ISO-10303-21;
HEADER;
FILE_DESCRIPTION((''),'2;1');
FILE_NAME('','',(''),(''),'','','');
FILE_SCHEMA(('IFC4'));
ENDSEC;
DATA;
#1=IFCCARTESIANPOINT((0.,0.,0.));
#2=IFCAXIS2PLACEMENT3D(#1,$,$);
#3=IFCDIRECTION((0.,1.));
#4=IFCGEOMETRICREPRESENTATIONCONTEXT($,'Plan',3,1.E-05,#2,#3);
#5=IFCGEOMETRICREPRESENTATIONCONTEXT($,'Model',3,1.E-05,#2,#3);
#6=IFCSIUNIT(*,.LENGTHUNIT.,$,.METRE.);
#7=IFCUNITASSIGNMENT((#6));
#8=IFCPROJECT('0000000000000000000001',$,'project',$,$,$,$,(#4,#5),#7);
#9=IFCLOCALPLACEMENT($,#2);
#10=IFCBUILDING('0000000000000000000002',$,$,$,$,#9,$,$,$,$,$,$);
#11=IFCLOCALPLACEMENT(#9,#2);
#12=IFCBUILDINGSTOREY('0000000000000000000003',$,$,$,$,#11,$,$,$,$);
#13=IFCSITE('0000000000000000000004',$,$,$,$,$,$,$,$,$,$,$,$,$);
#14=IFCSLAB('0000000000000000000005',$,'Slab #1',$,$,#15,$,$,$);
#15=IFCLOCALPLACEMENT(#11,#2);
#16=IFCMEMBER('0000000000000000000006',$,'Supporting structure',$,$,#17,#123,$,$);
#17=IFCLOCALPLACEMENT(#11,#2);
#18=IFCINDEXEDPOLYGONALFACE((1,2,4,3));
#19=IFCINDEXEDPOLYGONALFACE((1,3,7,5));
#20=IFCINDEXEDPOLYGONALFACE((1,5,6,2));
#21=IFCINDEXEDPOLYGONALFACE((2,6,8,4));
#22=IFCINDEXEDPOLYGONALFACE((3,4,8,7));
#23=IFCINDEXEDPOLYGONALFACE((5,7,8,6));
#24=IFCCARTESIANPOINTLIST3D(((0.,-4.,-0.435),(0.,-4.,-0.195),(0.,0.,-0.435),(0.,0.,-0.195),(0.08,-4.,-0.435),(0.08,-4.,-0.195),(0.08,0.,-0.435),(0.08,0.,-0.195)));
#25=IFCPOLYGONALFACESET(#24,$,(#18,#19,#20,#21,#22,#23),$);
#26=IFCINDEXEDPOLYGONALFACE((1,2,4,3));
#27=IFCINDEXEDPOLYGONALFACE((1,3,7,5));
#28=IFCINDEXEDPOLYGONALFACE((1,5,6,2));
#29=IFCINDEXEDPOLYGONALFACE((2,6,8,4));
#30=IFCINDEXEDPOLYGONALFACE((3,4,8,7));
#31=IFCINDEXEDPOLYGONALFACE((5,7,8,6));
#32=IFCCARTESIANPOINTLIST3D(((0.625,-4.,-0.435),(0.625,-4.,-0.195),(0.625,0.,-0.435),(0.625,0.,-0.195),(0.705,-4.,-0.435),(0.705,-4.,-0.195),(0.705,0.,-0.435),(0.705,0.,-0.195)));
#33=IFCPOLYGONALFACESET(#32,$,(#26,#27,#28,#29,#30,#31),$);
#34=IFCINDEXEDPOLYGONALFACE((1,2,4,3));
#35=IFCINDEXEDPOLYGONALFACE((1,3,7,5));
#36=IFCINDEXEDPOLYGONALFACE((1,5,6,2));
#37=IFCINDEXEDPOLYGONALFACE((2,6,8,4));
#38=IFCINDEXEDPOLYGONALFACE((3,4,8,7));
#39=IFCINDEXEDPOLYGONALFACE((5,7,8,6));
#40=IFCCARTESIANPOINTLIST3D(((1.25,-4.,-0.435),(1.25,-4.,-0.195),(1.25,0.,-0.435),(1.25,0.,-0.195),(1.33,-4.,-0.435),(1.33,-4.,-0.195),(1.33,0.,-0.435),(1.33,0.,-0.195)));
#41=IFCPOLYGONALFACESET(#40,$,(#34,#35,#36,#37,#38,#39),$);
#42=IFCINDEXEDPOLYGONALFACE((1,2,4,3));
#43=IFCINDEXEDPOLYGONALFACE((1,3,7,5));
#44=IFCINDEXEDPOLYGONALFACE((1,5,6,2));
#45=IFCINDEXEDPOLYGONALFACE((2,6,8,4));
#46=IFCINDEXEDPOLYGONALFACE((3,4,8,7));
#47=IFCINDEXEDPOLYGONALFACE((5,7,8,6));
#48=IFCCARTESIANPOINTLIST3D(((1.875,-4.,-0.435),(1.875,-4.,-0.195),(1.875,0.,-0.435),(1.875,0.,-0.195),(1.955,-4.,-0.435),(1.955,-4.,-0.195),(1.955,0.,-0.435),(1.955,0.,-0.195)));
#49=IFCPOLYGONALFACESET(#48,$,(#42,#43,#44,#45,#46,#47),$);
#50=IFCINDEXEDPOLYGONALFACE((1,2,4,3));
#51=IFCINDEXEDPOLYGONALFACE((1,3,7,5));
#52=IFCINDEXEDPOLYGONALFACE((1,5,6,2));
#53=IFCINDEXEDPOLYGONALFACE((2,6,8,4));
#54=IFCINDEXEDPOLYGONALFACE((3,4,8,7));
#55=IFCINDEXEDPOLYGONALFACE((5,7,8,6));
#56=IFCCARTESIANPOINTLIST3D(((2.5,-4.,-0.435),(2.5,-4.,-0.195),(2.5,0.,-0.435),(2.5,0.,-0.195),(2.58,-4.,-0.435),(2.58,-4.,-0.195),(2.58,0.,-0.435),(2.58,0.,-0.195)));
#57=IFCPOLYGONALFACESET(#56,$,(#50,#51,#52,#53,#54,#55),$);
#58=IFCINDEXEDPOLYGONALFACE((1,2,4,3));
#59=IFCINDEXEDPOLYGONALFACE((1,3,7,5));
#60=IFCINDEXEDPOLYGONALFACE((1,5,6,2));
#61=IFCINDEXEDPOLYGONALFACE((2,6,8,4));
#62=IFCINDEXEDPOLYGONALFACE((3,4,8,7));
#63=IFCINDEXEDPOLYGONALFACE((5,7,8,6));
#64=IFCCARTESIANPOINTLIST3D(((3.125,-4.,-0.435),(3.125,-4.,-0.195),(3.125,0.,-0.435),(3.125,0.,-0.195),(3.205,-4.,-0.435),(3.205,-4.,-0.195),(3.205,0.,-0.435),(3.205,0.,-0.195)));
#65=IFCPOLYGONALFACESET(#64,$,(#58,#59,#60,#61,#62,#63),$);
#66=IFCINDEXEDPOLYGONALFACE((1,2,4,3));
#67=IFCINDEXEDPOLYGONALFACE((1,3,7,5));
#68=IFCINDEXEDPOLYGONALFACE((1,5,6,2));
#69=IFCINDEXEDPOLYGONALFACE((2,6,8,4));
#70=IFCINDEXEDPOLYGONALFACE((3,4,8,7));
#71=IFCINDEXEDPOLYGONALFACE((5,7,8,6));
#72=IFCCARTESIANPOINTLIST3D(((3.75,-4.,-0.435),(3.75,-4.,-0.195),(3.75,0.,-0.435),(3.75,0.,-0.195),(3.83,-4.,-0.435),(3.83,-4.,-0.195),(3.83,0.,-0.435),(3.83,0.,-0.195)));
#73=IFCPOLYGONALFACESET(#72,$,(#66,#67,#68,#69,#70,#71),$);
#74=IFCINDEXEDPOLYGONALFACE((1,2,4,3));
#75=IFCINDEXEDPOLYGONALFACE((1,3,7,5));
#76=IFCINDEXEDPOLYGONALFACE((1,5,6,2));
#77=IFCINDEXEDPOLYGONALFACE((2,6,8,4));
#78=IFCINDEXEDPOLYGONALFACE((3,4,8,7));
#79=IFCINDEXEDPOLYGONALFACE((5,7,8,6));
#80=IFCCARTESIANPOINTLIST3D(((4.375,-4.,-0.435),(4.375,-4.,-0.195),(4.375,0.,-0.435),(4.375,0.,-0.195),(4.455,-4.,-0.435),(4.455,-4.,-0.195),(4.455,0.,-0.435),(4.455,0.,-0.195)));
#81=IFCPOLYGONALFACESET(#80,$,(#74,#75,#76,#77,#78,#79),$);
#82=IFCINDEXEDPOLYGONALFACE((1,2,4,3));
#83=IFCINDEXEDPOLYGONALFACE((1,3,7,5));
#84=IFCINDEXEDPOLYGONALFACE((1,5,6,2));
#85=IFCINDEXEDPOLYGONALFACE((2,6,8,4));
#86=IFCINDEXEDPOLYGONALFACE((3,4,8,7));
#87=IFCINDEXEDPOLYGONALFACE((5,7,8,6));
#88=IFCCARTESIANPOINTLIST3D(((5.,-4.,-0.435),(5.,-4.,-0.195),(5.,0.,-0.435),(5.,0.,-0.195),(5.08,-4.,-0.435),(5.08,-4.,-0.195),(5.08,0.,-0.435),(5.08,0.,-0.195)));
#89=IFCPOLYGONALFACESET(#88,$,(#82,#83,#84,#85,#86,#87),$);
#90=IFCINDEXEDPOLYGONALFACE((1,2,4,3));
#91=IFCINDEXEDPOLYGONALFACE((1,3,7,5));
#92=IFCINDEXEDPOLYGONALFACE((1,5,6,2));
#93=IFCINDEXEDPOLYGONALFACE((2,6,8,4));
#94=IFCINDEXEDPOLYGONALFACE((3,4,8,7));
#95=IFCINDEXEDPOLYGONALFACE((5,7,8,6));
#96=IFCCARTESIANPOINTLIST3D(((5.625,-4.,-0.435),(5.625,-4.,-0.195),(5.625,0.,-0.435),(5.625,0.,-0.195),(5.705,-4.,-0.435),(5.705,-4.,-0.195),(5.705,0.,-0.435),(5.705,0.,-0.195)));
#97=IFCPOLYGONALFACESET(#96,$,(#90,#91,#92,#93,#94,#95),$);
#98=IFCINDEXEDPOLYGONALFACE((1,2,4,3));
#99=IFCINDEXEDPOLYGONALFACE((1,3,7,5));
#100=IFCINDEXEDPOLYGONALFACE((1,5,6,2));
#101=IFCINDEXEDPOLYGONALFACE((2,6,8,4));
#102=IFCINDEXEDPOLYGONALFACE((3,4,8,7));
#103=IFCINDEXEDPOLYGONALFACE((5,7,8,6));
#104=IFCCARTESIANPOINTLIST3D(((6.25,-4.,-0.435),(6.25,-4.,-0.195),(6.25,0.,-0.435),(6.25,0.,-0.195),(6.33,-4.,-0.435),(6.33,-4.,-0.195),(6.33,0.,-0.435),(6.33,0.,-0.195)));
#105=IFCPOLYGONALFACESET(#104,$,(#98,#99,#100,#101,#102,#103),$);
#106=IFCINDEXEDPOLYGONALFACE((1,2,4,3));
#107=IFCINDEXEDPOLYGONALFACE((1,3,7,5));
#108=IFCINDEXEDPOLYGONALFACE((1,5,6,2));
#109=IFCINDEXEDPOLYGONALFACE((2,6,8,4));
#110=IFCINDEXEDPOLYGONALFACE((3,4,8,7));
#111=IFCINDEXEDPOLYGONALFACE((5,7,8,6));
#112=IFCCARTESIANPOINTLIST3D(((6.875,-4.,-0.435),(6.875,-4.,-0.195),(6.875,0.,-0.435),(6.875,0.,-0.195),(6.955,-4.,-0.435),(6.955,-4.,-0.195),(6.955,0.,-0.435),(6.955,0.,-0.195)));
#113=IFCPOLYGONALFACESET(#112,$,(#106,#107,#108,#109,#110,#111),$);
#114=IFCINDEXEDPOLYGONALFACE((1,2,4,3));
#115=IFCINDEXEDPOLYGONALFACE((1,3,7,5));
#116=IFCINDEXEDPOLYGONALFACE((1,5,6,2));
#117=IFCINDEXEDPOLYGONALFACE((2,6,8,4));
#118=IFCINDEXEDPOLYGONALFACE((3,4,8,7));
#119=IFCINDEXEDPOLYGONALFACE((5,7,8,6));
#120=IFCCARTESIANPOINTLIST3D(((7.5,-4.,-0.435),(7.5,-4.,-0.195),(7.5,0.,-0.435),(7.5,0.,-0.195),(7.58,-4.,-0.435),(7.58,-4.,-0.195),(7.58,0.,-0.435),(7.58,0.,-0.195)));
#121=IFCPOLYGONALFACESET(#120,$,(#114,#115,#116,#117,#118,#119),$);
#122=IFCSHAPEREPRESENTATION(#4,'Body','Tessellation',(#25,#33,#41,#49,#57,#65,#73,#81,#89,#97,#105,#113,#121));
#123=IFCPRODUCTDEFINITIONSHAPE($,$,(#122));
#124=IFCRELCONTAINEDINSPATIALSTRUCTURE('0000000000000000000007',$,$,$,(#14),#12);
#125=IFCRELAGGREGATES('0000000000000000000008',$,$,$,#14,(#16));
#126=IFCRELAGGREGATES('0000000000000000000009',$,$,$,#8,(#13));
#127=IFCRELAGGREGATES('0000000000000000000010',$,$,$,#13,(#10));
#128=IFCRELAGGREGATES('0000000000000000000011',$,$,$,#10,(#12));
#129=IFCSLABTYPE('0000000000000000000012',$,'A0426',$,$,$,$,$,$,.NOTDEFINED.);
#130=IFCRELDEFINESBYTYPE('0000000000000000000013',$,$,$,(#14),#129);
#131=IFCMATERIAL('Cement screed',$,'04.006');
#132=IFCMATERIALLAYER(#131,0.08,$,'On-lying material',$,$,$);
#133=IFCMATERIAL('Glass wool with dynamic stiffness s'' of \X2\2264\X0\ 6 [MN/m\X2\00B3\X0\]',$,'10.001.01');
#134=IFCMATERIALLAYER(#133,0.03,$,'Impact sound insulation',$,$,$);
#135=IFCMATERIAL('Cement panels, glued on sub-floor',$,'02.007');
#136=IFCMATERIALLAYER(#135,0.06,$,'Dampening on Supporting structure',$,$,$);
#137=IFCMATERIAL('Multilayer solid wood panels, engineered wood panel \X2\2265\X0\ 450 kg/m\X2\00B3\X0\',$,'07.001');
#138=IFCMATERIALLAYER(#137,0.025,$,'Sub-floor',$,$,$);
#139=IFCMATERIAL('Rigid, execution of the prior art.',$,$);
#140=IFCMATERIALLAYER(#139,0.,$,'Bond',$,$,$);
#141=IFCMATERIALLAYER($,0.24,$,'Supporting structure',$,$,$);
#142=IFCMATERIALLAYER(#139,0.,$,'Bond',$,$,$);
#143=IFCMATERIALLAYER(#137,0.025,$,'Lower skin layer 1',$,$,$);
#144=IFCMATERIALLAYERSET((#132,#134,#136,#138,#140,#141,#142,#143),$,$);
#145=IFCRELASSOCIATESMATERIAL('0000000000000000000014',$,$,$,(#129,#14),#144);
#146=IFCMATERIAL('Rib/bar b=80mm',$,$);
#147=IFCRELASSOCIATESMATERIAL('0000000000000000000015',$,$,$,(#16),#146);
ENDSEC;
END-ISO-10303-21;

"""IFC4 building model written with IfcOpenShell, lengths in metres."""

from ifc_helpers import new_model, si_unit, direction, frame, frame_2d, origin, place, context, project, spatial, rectangle, extrude, material, layer, layer_set, type_object, element, aggregate, save


model = new_model("IFC4")

# Units and contexts
plan_context = context("Plan", 3, precision=1e-05, world=origin(), true_north=direction((0.0, 1.0)))
model_context = context("Model", 3, precision=1e-05, world=origin(), true_north=direction((0.0, 1.0)))
ifc_project = project(units=[si_unit("LENGTHUNIT", "METRE")], contexts=[plan_context, model_context])

# Site, building, storey
site = spatial("IfcSite", under=ifc_project)
building_placement = place(None, origin())
building = spatial("IfcBuilding", under=site, at=building_placement)
storey_placement = place(building_placement, origin())
storey = spatial("IfcBuildingStorey", under=building, at=storey_placement)

# Slab, member
ifc_material_1 = material(Name="Cement screed", Category="04.006")
ifc_layer_1 = layer(ifc_material_1, 0.08, Name="On-lying material")
ifc_material_2 = material(Name="Glass wool with dynamic stiffness s' of ≤ 6 [MN/m³]", Category="10.001.01")
ifc_layer_2 = layer(ifc_material_2, 0.03, Name="Impact sound insulation")
ifc_material_3 = material(Name="Cement panels, glued on sub-floor", Category="02.007")
ifc_layer_3 = layer(ifc_material_3, 0.06, Name="Dampening on Supporting structure")
ifc_material_4 = material(Name="Multilayer solid wood panels, engineered wood panel ≥ 450 kg/m³", Category="07.001")
ifc_layer_4 = layer(ifc_material_4, 0.025, Name="Sub-floor")
ifc_material_5 = material(Name="Rigid, execution of the prior art.")
ifc_layer_5 = layer(ifc_material_5, 0.0, Name="Bond")
ifc_layer_6 = layer(None, 0.24, Name="Supporting structure")
ifc_layer_7 = layer(ifc_material_5, 0.0, Name="Bond")
ifc_layer_8 = layer(ifc_material_4, 0.025, Name="Lower skin layer 1")
ifc_layer_set = layer_set([ifc_layer_1, ifc_layer_2, ifc_layer_3, ifc_layer_4, ifc_layer_5, ifc_layer_6, ifc_layer_7, ifc_layer_8])
slab_type = type_object("IfcSlabType", Name="A0426", PredefinedType="NOTDEFINED", material=ifc_layer_set)
slab_placement = place(None, frame((0.0, 0.0, 0.0), z_axis=(0.0, 0.0, -1.0), x_axis=(1.0, 0.0, 0.0)))
slab = element("IfcSlab", 1, at=slab_placement, inside=storey, type_object=slab_type, material=ifc_layer_set, Name="Slab #1")
ifc_material_6 = material(Name="Rib/bar b=80mm")
member_1_placement = place(slab_placement, origin())
member_1 = element("IfcMember", 2, at=member_1_placement, material=ifc_material_6, Name="Supporting structure", context=plan_context, shape_type="SweptSolid", body=[
    extrude(rectangle(XDim=0.08, YDim=0.24, at=frame_2d((0.04, 0.12), x_axis=(1.0, 0.0))), frame((0.0, 4.0, 0.195), z_axis=(0.0, -1.0, 0.0), x_axis=(1.0, 0.0, 0.0)), (0.0, 0.0, 1.0), 4.0),
    extrude(rectangle(XDim=0.08, YDim=0.24, at=frame_2d((0.04, 0.12), x_axis=(1.0, 0.0))), frame((0.625, 4.0, 0.195), z_axis=(0.0, -1.0, 0.0), x_axis=(1.0, 0.0, 0.0)), (0.0, 0.0, 1.0), 4.0),
    extrude(rectangle(XDim=0.08, YDim=0.24, at=frame_2d((0.04, 0.12), x_axis=(1.0, 0.0))), frame((1.25, 4.0, 0.195), z_axis=(0.0, -1.0, 0.0), x_axis=(1.0, 0.0, 0.0)), (0.0, 0.0, 1.0), 4.0),
    extrude(rectangle(XDim=0.08, YDim=0.24, at=frame_2d((0.04, 0.12), x_axis=(1.0, 0.0))), frame((1.875, 4.0, 0.195), z_axis=(0.0, -1.0, 0.0), x_axis=(1.0, 0.0, 0.0)), (0.0, 0.0, 1.0), 4.0),
    extrude(rectangle(XDim=0.08, YDim=0.24, at=frame_2d((0.04, 0.12), x_axis=(1.0, 0.0))), frame((2.5, 4.0, 0.195), z_axis=(0.0, -1.0, 0.0), x_axis=(1.0, 0.0, 0.0)), (0.0, 0.0, 1.0), 4.0),
    extrude(rectangle(XDim=0.08, YDim=0.24, at=frame_2d((0.04, 0.12), x_axis=(1.0, 0.0))), frame((3.125, 4.0, 0.195), z_axis=(0.0, -1.0, 0.0), x_axis=(1.0, 0.0, 0.0)), (0.0, 0.0, 1.0), 4.0),
    extrude(rectangle(XDim=0.08, YDim=0.24, at=frame_2d((0.04, 0.12), x_axis=(1.0, 0.0))), frame((3.75, 4.0, 0.195), z_axis=(0.0, -1.0, 0.0), x_axis=(1.0, 0.0, 0.0)), (0.0, 0.0, 1.0), 4.0),
    extrude(rectangle(XDim=0.08, YDim=0.24, at=frame_2d((0.04, 0.12), x_axis=(1.0, 0.0))), frame((4.375, 4.0, 0.195), z_axis=(0.0, -1.0, 0.0), x_axis=(1.0, 0.0, 0.0)), (0.0, 0.0, 1.0), 4.0),
    extrude(rectangle(XDim=0.08, YDim=0.24, at=frame_2d((0.04, 0.12), x_axis=(1.0, 0.0))), frame((5.0, 4.0, 0.195), z_axis=(0.0, -1.0, 0.0), x_axis=(1.0, 0.0, 0.0)), (0.0, 0.0, 1.0), 4.0),
    extrude(rectangle(XDim=0.08, YDim=0.24, at=frame_2d((0.04, 0.12), x_axis=(1.0, 0.0))), frame((5.625, 4.0, 0.195), z_axis=(0.0, -1.0, 0.0), x_axis=(1.0, 0.0, 0.0)), (0.0, 0.0, 1.0), 4.0),
    extrude(rectangle(XDim=0.08, YDim=0.24, at=frame_2d((0.04, 0.12), x_axis=(1.0, 0.0))), frame((6.25, 4.0, 0.195), z_axis=(0.0, -1.0, 0.0), x_axis=(1.0, 0.0, 0.0)), (0.0, 0.0, 1.0), 4.0),
    extrude(rectangle(XDim=0.08, YDim=0.24, at=frame_2d((0.04, 0.12), x_axis=(1.0, 0.0))), frame((6.875, 4.0, 0.195), z_axis=(0.0, -1.0, 0.0), x_axis=(1.0, 0.0, 0.0)), (0.0, 0.0, 1.0), 4.0),
    extrude(rectangle(XDim=0.08, YDim=0.24, at=frame_2d((0.04, 0.12), x_axis=(1.0, 0.0))), frame((7.5, 4.0, 0.195), z_axis=(0.0, -1.0, 0.0), x_axis=(1.0, 0.0, 0.0)), (0.0, 0.0, 1.0), 4.0),
])
aggregate(slab, [member_1])

save(model, "model.ifc")
